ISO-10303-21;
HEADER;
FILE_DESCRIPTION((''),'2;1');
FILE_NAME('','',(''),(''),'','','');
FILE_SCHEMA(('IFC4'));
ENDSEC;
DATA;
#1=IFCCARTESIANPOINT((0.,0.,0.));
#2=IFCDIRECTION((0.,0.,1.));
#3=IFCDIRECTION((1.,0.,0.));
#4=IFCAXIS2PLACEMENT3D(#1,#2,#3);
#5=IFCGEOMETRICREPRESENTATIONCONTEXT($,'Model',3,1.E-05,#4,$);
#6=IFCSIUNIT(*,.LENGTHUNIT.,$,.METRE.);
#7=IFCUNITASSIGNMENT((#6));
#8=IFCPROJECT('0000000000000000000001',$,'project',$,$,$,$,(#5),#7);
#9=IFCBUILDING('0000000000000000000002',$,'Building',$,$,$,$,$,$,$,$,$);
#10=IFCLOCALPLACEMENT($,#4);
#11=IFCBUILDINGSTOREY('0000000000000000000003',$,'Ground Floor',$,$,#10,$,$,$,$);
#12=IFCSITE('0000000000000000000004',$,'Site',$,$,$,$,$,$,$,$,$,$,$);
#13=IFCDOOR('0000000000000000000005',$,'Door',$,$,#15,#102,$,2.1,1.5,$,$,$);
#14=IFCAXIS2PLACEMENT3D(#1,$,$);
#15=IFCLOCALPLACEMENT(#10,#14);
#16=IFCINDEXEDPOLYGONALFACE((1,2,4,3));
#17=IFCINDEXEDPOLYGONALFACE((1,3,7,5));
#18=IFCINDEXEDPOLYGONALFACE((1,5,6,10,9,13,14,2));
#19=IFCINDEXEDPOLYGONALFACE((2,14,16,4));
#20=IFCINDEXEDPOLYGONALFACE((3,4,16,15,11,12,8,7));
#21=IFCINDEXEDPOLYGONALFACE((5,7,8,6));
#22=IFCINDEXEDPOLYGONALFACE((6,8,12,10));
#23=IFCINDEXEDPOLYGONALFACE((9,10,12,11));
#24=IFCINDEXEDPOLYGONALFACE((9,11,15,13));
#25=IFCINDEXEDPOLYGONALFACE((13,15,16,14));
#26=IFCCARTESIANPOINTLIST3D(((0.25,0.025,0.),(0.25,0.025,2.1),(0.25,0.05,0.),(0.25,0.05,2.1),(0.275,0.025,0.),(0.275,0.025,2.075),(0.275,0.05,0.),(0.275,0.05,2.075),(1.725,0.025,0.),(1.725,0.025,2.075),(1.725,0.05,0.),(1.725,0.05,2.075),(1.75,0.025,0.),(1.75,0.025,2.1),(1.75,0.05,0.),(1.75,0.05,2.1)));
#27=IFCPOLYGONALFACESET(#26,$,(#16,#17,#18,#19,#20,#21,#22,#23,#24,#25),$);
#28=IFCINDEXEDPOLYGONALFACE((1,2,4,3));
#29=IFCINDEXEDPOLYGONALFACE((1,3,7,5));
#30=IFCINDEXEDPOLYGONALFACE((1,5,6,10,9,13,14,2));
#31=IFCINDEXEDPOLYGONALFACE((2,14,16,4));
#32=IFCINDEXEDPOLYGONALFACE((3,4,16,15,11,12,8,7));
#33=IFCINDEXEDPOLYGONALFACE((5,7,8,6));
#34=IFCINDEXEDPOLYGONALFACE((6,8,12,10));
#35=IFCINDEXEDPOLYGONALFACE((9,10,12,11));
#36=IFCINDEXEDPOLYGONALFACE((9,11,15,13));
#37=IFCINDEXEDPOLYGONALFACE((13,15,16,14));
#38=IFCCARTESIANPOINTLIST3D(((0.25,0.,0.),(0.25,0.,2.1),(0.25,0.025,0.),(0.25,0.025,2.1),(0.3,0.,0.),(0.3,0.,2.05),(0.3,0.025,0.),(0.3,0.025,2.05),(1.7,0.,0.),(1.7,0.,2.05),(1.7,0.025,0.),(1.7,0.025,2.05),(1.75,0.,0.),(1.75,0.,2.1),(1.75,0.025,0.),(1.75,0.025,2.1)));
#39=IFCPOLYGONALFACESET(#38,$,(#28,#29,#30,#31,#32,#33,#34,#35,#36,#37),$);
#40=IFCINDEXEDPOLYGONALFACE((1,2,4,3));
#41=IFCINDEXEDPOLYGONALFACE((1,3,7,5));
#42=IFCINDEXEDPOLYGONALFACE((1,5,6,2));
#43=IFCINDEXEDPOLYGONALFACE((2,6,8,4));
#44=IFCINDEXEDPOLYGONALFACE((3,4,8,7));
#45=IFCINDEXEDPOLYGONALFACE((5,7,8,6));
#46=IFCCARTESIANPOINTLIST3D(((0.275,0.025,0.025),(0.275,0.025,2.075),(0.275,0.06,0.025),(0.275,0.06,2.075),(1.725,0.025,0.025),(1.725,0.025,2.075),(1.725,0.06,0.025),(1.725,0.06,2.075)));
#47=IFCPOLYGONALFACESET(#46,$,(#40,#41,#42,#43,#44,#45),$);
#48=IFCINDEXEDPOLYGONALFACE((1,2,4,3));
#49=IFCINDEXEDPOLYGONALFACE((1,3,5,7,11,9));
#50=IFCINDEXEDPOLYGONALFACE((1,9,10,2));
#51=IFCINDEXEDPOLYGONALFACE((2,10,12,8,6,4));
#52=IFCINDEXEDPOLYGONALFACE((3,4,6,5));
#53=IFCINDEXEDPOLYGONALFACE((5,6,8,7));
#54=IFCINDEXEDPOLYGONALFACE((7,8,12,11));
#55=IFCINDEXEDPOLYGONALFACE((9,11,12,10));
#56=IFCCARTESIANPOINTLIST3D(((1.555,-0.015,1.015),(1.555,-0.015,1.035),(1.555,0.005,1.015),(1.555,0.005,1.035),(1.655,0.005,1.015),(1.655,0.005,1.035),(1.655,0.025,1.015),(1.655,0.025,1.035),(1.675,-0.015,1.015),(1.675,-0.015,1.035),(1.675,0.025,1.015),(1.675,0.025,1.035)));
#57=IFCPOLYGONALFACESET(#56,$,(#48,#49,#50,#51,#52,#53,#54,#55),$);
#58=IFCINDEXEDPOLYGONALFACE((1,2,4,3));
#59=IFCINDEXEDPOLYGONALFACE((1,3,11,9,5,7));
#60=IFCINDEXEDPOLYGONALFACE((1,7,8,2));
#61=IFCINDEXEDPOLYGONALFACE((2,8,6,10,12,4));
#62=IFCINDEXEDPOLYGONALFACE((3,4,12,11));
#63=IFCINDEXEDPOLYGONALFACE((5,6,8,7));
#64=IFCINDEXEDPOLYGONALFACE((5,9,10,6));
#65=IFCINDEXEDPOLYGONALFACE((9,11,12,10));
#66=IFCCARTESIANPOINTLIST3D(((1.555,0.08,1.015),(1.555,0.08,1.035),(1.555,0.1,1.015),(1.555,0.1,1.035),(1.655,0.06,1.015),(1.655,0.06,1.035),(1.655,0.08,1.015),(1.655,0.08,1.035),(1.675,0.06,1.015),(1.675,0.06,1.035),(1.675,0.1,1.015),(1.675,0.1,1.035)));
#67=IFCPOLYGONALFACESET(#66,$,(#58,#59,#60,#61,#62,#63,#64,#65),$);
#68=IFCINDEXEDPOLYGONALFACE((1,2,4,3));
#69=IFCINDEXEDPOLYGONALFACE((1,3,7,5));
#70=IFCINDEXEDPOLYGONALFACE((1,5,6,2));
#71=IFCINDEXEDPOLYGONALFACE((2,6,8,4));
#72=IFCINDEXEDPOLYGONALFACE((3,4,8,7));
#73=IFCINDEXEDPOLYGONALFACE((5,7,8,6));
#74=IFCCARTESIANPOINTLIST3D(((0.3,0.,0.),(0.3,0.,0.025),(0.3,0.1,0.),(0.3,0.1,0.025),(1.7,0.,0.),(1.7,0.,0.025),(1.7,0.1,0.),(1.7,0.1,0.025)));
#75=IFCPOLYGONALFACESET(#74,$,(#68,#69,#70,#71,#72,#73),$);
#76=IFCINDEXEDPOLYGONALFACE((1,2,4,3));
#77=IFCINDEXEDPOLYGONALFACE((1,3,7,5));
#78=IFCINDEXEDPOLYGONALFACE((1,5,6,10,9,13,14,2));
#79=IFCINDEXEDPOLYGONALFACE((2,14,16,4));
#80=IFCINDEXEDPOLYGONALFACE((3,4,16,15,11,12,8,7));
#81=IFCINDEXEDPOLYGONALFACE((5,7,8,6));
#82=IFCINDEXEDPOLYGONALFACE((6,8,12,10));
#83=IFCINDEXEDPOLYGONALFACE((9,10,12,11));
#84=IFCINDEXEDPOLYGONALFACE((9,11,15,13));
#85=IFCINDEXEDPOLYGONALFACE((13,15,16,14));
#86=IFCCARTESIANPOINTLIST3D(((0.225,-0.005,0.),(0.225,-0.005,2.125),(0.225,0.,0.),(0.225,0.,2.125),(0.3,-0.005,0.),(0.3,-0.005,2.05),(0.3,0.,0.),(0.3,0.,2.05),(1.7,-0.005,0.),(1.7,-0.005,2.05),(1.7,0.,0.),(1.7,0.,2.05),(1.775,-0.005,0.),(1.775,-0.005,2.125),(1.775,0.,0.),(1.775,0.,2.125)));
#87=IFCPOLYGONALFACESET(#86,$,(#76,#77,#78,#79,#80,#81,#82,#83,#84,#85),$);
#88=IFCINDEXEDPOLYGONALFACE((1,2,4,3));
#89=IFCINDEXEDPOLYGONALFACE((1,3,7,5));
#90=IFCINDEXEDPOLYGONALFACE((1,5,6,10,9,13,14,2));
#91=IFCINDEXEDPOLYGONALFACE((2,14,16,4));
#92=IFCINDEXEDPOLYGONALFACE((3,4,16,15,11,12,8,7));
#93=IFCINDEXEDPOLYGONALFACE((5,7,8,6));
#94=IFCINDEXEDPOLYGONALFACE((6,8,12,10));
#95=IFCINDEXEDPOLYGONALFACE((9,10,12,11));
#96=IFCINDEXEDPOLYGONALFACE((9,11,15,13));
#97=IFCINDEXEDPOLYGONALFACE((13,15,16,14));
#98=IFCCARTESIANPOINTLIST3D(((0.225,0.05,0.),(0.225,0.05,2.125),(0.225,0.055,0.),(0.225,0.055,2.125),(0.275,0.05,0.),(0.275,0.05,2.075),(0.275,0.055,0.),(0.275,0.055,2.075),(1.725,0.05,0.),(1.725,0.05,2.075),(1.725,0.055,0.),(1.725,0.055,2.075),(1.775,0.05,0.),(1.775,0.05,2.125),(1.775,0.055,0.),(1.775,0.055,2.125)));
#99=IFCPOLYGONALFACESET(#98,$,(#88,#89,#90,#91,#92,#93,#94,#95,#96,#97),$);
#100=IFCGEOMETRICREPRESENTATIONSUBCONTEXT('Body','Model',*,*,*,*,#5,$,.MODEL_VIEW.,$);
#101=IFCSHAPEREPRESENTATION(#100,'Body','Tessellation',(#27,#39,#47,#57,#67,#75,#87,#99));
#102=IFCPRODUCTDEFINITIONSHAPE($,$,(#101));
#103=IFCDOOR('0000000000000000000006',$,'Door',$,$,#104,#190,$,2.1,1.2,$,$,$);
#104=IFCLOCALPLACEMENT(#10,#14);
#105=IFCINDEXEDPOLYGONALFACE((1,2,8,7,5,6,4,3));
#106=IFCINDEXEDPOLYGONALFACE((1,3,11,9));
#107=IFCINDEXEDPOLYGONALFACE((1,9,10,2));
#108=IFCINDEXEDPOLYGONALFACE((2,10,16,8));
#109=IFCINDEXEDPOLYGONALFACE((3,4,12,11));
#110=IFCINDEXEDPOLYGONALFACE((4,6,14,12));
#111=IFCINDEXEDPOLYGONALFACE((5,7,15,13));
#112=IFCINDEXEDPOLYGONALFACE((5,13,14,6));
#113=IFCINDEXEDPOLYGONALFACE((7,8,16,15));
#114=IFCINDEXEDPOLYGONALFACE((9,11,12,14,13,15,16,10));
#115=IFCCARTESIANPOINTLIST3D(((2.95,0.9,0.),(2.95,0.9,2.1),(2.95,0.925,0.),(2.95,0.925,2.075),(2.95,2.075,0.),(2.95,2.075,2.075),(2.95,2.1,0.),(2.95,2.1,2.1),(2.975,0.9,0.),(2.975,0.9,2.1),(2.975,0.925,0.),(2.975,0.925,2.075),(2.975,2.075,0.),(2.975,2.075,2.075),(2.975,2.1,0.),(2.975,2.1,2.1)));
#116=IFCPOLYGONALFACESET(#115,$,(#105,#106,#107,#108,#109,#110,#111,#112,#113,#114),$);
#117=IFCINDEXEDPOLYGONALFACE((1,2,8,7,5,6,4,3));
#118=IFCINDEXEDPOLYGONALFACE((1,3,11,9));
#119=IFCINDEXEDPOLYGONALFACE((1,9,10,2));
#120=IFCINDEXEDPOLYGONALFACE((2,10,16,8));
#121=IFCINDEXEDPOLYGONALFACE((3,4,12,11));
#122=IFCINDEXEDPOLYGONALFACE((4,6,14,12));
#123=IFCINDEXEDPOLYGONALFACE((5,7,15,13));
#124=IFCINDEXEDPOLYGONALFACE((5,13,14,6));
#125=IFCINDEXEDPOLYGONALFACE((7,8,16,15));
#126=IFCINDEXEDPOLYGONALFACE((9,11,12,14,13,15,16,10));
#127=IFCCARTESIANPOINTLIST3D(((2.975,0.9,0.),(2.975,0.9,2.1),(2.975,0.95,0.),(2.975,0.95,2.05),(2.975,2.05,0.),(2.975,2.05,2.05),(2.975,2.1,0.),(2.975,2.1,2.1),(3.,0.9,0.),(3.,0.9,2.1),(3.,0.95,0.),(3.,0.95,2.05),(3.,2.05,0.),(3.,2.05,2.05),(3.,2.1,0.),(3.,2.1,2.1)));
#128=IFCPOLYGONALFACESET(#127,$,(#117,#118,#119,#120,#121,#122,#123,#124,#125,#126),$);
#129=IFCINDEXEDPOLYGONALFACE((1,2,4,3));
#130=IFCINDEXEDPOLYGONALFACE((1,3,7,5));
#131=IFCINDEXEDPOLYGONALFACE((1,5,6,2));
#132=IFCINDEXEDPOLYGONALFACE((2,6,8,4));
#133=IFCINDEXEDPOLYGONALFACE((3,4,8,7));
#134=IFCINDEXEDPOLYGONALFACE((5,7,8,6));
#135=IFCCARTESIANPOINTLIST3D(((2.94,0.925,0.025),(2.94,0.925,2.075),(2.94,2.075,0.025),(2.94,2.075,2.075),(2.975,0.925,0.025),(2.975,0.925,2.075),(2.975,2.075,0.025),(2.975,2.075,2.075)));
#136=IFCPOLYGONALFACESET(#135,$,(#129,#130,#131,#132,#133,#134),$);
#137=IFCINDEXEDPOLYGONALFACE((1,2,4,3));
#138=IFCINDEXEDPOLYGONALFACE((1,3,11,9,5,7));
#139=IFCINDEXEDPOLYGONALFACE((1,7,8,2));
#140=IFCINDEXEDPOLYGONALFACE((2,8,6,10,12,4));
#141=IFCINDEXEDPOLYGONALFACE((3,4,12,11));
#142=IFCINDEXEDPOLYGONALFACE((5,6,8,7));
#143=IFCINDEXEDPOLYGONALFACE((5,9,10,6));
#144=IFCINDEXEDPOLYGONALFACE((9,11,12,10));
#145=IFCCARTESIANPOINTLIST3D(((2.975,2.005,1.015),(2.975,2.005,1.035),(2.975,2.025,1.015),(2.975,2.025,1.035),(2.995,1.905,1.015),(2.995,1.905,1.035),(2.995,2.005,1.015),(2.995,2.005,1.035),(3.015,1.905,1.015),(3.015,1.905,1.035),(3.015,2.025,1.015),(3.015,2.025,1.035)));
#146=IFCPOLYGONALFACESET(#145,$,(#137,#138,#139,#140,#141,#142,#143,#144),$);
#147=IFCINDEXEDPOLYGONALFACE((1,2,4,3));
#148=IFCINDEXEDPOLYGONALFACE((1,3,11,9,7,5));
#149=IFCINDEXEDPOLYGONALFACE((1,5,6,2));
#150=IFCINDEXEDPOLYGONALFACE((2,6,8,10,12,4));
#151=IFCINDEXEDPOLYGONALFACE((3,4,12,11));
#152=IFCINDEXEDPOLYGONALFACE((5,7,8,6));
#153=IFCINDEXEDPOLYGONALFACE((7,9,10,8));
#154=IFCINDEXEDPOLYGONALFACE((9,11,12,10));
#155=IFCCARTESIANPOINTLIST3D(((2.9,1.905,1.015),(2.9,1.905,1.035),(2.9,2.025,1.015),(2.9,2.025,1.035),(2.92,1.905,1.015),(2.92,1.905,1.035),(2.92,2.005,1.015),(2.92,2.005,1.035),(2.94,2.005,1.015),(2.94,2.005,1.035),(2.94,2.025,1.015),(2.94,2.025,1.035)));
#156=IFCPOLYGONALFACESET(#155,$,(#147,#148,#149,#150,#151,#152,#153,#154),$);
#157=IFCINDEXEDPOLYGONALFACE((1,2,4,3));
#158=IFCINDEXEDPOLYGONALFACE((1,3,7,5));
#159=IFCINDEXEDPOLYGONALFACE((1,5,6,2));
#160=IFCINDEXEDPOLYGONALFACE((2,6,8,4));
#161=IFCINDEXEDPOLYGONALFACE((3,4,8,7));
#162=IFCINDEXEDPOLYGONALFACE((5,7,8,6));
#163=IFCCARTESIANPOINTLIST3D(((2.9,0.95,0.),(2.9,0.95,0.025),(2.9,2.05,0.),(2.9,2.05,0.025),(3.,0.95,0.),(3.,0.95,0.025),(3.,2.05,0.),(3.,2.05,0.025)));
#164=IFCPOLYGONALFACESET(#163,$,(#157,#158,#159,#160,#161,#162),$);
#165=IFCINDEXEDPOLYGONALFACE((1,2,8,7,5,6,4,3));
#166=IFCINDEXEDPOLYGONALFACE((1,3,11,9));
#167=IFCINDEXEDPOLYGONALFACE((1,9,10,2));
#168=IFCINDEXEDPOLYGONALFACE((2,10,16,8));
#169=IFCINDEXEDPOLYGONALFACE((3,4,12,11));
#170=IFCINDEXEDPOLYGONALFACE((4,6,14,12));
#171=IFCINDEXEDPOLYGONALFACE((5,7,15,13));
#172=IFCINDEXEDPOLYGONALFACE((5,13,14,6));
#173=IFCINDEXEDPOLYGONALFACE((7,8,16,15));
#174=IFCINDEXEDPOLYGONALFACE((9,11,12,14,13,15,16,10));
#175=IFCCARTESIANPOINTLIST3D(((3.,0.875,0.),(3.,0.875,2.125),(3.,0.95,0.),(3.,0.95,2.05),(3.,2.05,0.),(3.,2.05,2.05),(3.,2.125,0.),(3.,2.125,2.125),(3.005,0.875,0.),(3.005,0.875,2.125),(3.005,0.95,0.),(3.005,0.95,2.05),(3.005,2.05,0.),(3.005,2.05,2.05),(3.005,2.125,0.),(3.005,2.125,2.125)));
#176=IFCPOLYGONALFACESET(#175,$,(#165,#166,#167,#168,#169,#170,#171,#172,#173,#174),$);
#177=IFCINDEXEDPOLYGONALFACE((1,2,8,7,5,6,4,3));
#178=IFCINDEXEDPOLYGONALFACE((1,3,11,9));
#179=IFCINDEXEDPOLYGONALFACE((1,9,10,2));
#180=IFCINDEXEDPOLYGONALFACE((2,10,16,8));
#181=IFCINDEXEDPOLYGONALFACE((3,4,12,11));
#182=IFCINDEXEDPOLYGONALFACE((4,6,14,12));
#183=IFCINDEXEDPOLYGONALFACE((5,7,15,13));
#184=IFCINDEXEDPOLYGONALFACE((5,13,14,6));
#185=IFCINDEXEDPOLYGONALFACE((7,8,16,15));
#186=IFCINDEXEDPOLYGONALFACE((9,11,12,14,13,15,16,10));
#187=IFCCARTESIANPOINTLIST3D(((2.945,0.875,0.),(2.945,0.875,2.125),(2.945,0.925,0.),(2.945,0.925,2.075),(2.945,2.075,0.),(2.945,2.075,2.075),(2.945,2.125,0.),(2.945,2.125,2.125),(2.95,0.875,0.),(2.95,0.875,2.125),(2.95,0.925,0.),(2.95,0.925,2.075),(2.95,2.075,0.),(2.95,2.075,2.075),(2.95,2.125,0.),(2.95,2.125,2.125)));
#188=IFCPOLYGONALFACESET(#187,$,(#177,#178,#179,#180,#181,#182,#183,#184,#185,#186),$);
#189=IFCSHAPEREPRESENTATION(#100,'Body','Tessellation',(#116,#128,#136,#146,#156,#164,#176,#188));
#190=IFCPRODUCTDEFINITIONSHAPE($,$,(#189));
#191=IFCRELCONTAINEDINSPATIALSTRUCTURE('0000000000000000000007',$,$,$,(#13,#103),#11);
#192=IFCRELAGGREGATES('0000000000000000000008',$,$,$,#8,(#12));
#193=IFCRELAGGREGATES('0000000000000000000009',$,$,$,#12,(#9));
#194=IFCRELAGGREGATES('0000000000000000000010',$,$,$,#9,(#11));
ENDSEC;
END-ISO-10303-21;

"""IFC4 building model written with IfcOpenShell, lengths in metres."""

from ifc_helpers import new_model, si_unit, frame, origin_with_axes, place, context, subcontext, project, spatial, line, indexed_curve, outline, extrude, element, save


model = new_model("IFC4")

# Units and contexts
model_context = context("Model", 3, precision=1e-05, world=origin_with_axes())
body_context = subcontext(model_context, "Body", "Model", "MODEL_VIEW")
ifc_project = project(units=[si_unit("LENGTHUNIT", "METRE")], contexts=[model_context])

# Site, building, storey
site = spatial("IfcSite", under=ifc_project, Name="Site")
building = spatial("IfcBuilding", under=site, Name="Building")
storey_placement = place(None, origin_with_axes())
storey = spatial("IfcBuildingStorey", under=building, at=storey_placement, Name="Ground Floor")

# Doors
door_1_placement = place(storey_placement, frame((0.25, 0.0, 0.0), z_axis=(0.0, 0.0, 1.0), x_axis=(1.0, 0.0, 0.0)))
element("IfcDoor", 1, at=door_1_placement, inside=storey, Name="Door", OverallHeight=2.1, OverallWidth=1.5, context=body_context, shape_type="SweptSolid", body=[
    extrude(outline(indexed_curve([(0.0, 0.0), (0.0, 2.1), (1.5, 2.1), (1.5, 0.0), (1.475, 0.0), (1.475, 2.075), (0.025, 2.075), (0.025, 0.0)], segments=[line(1, 2, 3, 4, 5, 6, 7, 8, 1)])), frame((0.0, 0.025, 0.0), z_axis=(0.0, -1.0, 0.0), x_axis=(1.0, 0.0, 0.0)), (0.0, 0.0, -1.0), 0.025),
    extrude(outline(indexed_curve([(0.0, 0.0), (0.0, 2.1), (1.5, 2.1), (1.5, 0.0), (1.45, 0.0), (1.45, 2.05), (0.05, 2.05), (0.05, 0.0)], segments=[line(1, 2, 3, 4, 5, 6, 7, 8, 1)])), frame((0.0, 0.0, 0.0), z_axis=(0.0, -1.0, 0.0), x_axis=(1.0, 0.0, 0.0)), (0.0, 0.0, -1.0), 0.025),
    extrude(outline(indexed_curve([(0.0, 0.0), (1.45, 0.0), (1.45, 0.035), (0.0, 0.035)], segments=[line(1, 2, 3, 4, 1)])), frame((0.025, 0.025, 0.025), z_axis=(0.0, 0.0, 1.0), x_axis=(1.0, 0.0, 0.0)), (0.0, 0.0, 1.0), 2.05),
    extrude(outline(indexed_curve([(0.0, 0.0), (0.0, -0.04), (-0.12, -0.04), (-0.12, -0.02), (-0.02, -0.02), (-0.02, 0.0)], segments=[line(1, 2, 3, 4, 5, 6, 1)])), frame((1.425, 0.025, 1.015), z_axis=(0.0, 0.0, 1.0), x_axis=(1.0, 0.0, 0.0)), (0.0, 0.0, 1.0), 0.02),
    extrude(outline(indexed_curve([(0.0, 0.0), (0.0, 0.04), (-0.12, 0.04), (-0.12, 0.02), (-0.02, 0.02), (-0.02, 0.0)], segments=[line(1, 2, 3, 4, 5, 6, 1)])), frame((1.425, 0.06, 1.015), z_axis=(0.0, 0.0, 1.0), x_axis=(1.0, 0.0, 0.0)), (0.0, 0.0, 1.0), 0.02),
    extrude(outline(indexed_curve([(0.0, 0.0), (1.4, 0.0), (1.4, 0.1), (0.0, 0.1)], segments=[line(1, 2, 3, 4, 1)])), frame((0.05, 0.0, 0.0), z_axis=(0.0, 0.0, 1.0), x_axis=(1.0, 0.0, 0.0)), (0.0, 0.0, 1.0), 0.025),
    extrude(outline(indexed_curve([(0.0, 0.0), (0.0, 2.125), (1.55, 2.125), (1.55, 0.0), (1.475, 0.0), (1.475, 2.05), (0.075, 2.05), (0.075, 0.0)], segments=[line(1, 2, 3, 4, 5, 6, 7, 8, 1)])), frame((-0.025, -0.005, 0.0), z_axis=(0.0, -1.0, 0.0), x_axis=(1.0, 0.0, 0.0)), (0.0, 0.0, -1.0), 0.005),
    extrude(outline(indexed_curve([(0.0, 0.0), (0.0, 2.125), (1.55, 2.125), (1.55, 0.0), (1.5, 0.0), (1.5, 2.075), (0.05, 2.075), (0.05, 0.0)], segments=[line(1, 2, 3, 4, 5, 6, 7, 8, 1)])), frame((-0.025, 0.05, 0.0), z_axis=(0.0, -1.0, 0.0), x_axis=(1.0, 0.0, 0.0)), (0.0, 0.0, -1.0), 0.005),
])
door_2_placement = place(storey_placement, frame((3.0, 0.9, 0.0), z_axis=(0.0, 0.0, 1.0), x_axis=(0.0, 1.0, 0.0)))
element("IfcDoor", 2, at=door_2_placement, inside=storey, Name="Door", OverallHeight=2.1, OverallWidth=1.2, context=body_context, shape_type="SweptSolid", body=[
    extrude(outline(indexed_curve([(0.0, 0.0), (0.0, 2.1), (1.2, 2.1), (1.2, 0.0), (1.175, 0.0), (1.175, 2.075), (0.025, 2.075), (0.025, 0.0)], segments=[line(1, 2, 3, 4, 5, 6, 7, 8, 1)])), frame((0.0, 0.025, 0.0), z_axis=(0.0, -1.0, 0.0), x_axis=(1.0, 0.0, 0.0)), (0.0, 0.0, -1.0), 0.025),
    extrude(outline(indexed_curve([(0.0, 0.0), (0.0, 2.1), (1.2, 2.1), (1.2, 0.0), (1.15, 0.0), (1.15, 2.05), (0.05, 2.05), (0.05, 0.0)], segments=[line(1, 2, 3, 4, 5, 6, 7, 8, 1)])), frame((0.0, 0.0, 0.0), z_axis=(0.0, -1.0, 0.0), x_axis=(1.0, 0.0, 0.0)), (0.0, 0.0, -1.0), 0.025),
    extrude(outline(indexed_curve([(0.0, 0.0), (1.15, 0.0), (1.15, 0.035), (0.0, 0.035)], segments=[line(1, 2, 3, 4, 1)])), frame((0.025, 0.025, 0.025), z_axis=(0.0, 0.0, 1.0), x_axis=(1.0, 0.0, 0.0)), (0.0, 0.0, 1.0), 2.05),
    extrude(outline(indexed_curve([(0.0, 0.0), (0.0, -0.04), (-0.12, -0.04), (-0.12, -0.02), (-0.02, -0.02), (-0.02, 0.0)], segments=[line(1, 2, 3, 4, 5, 6, 1)])), frame((1.125, 0.025, 1.015), z_axis=(0.0, 0.0, 1.0), x_axis=(1.0, 0.0, 0.0)), (0.0, 0.0, 1.0), 0.02),
    extrude(outline(indexed_curve([(0.0, 0.0), (0.0, 0.04), (-0.12, 0.04), (-0.12, 0.02), (-0.02, 0.02), (-0.02, 0.0)], segments=[line(1, 2, 3, 4, 5, 6, 1)])), frame((1.125, 0.06, 1.015), z_axis=(0.0, 0.0, 1.0), x_axis=(1.0, 0.0, 0.0)), (0.0, 0.0, 1.0), 0.02),
    extrude(outline(indexed_curve([(0.0, 0.0), (1.1, 0.0), (1.1, 0.1), (0.0, 0.1)], segments=[line(1, 2, 3, 4, 1)])), frame((0.05, 0.0, 0.0), z_axis=(0.0, 0.0, 1.0), x_axis=(1.0, 0.0, 0.0)), (0.0, 0.0, 1.0), 0.025),
    extrude(outline(indexed_curve([(0.0, 0.0), (0.0, 2.125), (1.25, 2.125), (1.25, 0.0), (1.175, 0.0), (1.175, 2.05), (0.075, 2.05), (0.075, 0.0)], segments=[line(1, 2, 3, 4, 5, 6, 7, 8, 1)])), frame((-0.025, -0.005, 0.0), z_axis=(0.0, -1.0, 0.0), x_axis=(1.0, 0.0, 0.0)), (0.0, 0.0, -1.0), 0.005),
    extrude(outline(indexed_curve([(0.0, 0.0), (0.0, 2.125), (1.25, 2.125), (1.25, 0.0), (1.2, 0.0), (1.2, 2.075), (0.05, 2.075), (0.05, 0.0)], segments=[line(1, 2, 3, 4, 5, 6, 7, 8, 1)])), frame((-0.025, 0.05, 0.0), z_axis=(0.0, -1.0, 0.0), x_axis=(1.0, 0.0, 0.0)), (0.0, 0.0, -1.0), 0.005),
])

save(model, "model.ifc")
